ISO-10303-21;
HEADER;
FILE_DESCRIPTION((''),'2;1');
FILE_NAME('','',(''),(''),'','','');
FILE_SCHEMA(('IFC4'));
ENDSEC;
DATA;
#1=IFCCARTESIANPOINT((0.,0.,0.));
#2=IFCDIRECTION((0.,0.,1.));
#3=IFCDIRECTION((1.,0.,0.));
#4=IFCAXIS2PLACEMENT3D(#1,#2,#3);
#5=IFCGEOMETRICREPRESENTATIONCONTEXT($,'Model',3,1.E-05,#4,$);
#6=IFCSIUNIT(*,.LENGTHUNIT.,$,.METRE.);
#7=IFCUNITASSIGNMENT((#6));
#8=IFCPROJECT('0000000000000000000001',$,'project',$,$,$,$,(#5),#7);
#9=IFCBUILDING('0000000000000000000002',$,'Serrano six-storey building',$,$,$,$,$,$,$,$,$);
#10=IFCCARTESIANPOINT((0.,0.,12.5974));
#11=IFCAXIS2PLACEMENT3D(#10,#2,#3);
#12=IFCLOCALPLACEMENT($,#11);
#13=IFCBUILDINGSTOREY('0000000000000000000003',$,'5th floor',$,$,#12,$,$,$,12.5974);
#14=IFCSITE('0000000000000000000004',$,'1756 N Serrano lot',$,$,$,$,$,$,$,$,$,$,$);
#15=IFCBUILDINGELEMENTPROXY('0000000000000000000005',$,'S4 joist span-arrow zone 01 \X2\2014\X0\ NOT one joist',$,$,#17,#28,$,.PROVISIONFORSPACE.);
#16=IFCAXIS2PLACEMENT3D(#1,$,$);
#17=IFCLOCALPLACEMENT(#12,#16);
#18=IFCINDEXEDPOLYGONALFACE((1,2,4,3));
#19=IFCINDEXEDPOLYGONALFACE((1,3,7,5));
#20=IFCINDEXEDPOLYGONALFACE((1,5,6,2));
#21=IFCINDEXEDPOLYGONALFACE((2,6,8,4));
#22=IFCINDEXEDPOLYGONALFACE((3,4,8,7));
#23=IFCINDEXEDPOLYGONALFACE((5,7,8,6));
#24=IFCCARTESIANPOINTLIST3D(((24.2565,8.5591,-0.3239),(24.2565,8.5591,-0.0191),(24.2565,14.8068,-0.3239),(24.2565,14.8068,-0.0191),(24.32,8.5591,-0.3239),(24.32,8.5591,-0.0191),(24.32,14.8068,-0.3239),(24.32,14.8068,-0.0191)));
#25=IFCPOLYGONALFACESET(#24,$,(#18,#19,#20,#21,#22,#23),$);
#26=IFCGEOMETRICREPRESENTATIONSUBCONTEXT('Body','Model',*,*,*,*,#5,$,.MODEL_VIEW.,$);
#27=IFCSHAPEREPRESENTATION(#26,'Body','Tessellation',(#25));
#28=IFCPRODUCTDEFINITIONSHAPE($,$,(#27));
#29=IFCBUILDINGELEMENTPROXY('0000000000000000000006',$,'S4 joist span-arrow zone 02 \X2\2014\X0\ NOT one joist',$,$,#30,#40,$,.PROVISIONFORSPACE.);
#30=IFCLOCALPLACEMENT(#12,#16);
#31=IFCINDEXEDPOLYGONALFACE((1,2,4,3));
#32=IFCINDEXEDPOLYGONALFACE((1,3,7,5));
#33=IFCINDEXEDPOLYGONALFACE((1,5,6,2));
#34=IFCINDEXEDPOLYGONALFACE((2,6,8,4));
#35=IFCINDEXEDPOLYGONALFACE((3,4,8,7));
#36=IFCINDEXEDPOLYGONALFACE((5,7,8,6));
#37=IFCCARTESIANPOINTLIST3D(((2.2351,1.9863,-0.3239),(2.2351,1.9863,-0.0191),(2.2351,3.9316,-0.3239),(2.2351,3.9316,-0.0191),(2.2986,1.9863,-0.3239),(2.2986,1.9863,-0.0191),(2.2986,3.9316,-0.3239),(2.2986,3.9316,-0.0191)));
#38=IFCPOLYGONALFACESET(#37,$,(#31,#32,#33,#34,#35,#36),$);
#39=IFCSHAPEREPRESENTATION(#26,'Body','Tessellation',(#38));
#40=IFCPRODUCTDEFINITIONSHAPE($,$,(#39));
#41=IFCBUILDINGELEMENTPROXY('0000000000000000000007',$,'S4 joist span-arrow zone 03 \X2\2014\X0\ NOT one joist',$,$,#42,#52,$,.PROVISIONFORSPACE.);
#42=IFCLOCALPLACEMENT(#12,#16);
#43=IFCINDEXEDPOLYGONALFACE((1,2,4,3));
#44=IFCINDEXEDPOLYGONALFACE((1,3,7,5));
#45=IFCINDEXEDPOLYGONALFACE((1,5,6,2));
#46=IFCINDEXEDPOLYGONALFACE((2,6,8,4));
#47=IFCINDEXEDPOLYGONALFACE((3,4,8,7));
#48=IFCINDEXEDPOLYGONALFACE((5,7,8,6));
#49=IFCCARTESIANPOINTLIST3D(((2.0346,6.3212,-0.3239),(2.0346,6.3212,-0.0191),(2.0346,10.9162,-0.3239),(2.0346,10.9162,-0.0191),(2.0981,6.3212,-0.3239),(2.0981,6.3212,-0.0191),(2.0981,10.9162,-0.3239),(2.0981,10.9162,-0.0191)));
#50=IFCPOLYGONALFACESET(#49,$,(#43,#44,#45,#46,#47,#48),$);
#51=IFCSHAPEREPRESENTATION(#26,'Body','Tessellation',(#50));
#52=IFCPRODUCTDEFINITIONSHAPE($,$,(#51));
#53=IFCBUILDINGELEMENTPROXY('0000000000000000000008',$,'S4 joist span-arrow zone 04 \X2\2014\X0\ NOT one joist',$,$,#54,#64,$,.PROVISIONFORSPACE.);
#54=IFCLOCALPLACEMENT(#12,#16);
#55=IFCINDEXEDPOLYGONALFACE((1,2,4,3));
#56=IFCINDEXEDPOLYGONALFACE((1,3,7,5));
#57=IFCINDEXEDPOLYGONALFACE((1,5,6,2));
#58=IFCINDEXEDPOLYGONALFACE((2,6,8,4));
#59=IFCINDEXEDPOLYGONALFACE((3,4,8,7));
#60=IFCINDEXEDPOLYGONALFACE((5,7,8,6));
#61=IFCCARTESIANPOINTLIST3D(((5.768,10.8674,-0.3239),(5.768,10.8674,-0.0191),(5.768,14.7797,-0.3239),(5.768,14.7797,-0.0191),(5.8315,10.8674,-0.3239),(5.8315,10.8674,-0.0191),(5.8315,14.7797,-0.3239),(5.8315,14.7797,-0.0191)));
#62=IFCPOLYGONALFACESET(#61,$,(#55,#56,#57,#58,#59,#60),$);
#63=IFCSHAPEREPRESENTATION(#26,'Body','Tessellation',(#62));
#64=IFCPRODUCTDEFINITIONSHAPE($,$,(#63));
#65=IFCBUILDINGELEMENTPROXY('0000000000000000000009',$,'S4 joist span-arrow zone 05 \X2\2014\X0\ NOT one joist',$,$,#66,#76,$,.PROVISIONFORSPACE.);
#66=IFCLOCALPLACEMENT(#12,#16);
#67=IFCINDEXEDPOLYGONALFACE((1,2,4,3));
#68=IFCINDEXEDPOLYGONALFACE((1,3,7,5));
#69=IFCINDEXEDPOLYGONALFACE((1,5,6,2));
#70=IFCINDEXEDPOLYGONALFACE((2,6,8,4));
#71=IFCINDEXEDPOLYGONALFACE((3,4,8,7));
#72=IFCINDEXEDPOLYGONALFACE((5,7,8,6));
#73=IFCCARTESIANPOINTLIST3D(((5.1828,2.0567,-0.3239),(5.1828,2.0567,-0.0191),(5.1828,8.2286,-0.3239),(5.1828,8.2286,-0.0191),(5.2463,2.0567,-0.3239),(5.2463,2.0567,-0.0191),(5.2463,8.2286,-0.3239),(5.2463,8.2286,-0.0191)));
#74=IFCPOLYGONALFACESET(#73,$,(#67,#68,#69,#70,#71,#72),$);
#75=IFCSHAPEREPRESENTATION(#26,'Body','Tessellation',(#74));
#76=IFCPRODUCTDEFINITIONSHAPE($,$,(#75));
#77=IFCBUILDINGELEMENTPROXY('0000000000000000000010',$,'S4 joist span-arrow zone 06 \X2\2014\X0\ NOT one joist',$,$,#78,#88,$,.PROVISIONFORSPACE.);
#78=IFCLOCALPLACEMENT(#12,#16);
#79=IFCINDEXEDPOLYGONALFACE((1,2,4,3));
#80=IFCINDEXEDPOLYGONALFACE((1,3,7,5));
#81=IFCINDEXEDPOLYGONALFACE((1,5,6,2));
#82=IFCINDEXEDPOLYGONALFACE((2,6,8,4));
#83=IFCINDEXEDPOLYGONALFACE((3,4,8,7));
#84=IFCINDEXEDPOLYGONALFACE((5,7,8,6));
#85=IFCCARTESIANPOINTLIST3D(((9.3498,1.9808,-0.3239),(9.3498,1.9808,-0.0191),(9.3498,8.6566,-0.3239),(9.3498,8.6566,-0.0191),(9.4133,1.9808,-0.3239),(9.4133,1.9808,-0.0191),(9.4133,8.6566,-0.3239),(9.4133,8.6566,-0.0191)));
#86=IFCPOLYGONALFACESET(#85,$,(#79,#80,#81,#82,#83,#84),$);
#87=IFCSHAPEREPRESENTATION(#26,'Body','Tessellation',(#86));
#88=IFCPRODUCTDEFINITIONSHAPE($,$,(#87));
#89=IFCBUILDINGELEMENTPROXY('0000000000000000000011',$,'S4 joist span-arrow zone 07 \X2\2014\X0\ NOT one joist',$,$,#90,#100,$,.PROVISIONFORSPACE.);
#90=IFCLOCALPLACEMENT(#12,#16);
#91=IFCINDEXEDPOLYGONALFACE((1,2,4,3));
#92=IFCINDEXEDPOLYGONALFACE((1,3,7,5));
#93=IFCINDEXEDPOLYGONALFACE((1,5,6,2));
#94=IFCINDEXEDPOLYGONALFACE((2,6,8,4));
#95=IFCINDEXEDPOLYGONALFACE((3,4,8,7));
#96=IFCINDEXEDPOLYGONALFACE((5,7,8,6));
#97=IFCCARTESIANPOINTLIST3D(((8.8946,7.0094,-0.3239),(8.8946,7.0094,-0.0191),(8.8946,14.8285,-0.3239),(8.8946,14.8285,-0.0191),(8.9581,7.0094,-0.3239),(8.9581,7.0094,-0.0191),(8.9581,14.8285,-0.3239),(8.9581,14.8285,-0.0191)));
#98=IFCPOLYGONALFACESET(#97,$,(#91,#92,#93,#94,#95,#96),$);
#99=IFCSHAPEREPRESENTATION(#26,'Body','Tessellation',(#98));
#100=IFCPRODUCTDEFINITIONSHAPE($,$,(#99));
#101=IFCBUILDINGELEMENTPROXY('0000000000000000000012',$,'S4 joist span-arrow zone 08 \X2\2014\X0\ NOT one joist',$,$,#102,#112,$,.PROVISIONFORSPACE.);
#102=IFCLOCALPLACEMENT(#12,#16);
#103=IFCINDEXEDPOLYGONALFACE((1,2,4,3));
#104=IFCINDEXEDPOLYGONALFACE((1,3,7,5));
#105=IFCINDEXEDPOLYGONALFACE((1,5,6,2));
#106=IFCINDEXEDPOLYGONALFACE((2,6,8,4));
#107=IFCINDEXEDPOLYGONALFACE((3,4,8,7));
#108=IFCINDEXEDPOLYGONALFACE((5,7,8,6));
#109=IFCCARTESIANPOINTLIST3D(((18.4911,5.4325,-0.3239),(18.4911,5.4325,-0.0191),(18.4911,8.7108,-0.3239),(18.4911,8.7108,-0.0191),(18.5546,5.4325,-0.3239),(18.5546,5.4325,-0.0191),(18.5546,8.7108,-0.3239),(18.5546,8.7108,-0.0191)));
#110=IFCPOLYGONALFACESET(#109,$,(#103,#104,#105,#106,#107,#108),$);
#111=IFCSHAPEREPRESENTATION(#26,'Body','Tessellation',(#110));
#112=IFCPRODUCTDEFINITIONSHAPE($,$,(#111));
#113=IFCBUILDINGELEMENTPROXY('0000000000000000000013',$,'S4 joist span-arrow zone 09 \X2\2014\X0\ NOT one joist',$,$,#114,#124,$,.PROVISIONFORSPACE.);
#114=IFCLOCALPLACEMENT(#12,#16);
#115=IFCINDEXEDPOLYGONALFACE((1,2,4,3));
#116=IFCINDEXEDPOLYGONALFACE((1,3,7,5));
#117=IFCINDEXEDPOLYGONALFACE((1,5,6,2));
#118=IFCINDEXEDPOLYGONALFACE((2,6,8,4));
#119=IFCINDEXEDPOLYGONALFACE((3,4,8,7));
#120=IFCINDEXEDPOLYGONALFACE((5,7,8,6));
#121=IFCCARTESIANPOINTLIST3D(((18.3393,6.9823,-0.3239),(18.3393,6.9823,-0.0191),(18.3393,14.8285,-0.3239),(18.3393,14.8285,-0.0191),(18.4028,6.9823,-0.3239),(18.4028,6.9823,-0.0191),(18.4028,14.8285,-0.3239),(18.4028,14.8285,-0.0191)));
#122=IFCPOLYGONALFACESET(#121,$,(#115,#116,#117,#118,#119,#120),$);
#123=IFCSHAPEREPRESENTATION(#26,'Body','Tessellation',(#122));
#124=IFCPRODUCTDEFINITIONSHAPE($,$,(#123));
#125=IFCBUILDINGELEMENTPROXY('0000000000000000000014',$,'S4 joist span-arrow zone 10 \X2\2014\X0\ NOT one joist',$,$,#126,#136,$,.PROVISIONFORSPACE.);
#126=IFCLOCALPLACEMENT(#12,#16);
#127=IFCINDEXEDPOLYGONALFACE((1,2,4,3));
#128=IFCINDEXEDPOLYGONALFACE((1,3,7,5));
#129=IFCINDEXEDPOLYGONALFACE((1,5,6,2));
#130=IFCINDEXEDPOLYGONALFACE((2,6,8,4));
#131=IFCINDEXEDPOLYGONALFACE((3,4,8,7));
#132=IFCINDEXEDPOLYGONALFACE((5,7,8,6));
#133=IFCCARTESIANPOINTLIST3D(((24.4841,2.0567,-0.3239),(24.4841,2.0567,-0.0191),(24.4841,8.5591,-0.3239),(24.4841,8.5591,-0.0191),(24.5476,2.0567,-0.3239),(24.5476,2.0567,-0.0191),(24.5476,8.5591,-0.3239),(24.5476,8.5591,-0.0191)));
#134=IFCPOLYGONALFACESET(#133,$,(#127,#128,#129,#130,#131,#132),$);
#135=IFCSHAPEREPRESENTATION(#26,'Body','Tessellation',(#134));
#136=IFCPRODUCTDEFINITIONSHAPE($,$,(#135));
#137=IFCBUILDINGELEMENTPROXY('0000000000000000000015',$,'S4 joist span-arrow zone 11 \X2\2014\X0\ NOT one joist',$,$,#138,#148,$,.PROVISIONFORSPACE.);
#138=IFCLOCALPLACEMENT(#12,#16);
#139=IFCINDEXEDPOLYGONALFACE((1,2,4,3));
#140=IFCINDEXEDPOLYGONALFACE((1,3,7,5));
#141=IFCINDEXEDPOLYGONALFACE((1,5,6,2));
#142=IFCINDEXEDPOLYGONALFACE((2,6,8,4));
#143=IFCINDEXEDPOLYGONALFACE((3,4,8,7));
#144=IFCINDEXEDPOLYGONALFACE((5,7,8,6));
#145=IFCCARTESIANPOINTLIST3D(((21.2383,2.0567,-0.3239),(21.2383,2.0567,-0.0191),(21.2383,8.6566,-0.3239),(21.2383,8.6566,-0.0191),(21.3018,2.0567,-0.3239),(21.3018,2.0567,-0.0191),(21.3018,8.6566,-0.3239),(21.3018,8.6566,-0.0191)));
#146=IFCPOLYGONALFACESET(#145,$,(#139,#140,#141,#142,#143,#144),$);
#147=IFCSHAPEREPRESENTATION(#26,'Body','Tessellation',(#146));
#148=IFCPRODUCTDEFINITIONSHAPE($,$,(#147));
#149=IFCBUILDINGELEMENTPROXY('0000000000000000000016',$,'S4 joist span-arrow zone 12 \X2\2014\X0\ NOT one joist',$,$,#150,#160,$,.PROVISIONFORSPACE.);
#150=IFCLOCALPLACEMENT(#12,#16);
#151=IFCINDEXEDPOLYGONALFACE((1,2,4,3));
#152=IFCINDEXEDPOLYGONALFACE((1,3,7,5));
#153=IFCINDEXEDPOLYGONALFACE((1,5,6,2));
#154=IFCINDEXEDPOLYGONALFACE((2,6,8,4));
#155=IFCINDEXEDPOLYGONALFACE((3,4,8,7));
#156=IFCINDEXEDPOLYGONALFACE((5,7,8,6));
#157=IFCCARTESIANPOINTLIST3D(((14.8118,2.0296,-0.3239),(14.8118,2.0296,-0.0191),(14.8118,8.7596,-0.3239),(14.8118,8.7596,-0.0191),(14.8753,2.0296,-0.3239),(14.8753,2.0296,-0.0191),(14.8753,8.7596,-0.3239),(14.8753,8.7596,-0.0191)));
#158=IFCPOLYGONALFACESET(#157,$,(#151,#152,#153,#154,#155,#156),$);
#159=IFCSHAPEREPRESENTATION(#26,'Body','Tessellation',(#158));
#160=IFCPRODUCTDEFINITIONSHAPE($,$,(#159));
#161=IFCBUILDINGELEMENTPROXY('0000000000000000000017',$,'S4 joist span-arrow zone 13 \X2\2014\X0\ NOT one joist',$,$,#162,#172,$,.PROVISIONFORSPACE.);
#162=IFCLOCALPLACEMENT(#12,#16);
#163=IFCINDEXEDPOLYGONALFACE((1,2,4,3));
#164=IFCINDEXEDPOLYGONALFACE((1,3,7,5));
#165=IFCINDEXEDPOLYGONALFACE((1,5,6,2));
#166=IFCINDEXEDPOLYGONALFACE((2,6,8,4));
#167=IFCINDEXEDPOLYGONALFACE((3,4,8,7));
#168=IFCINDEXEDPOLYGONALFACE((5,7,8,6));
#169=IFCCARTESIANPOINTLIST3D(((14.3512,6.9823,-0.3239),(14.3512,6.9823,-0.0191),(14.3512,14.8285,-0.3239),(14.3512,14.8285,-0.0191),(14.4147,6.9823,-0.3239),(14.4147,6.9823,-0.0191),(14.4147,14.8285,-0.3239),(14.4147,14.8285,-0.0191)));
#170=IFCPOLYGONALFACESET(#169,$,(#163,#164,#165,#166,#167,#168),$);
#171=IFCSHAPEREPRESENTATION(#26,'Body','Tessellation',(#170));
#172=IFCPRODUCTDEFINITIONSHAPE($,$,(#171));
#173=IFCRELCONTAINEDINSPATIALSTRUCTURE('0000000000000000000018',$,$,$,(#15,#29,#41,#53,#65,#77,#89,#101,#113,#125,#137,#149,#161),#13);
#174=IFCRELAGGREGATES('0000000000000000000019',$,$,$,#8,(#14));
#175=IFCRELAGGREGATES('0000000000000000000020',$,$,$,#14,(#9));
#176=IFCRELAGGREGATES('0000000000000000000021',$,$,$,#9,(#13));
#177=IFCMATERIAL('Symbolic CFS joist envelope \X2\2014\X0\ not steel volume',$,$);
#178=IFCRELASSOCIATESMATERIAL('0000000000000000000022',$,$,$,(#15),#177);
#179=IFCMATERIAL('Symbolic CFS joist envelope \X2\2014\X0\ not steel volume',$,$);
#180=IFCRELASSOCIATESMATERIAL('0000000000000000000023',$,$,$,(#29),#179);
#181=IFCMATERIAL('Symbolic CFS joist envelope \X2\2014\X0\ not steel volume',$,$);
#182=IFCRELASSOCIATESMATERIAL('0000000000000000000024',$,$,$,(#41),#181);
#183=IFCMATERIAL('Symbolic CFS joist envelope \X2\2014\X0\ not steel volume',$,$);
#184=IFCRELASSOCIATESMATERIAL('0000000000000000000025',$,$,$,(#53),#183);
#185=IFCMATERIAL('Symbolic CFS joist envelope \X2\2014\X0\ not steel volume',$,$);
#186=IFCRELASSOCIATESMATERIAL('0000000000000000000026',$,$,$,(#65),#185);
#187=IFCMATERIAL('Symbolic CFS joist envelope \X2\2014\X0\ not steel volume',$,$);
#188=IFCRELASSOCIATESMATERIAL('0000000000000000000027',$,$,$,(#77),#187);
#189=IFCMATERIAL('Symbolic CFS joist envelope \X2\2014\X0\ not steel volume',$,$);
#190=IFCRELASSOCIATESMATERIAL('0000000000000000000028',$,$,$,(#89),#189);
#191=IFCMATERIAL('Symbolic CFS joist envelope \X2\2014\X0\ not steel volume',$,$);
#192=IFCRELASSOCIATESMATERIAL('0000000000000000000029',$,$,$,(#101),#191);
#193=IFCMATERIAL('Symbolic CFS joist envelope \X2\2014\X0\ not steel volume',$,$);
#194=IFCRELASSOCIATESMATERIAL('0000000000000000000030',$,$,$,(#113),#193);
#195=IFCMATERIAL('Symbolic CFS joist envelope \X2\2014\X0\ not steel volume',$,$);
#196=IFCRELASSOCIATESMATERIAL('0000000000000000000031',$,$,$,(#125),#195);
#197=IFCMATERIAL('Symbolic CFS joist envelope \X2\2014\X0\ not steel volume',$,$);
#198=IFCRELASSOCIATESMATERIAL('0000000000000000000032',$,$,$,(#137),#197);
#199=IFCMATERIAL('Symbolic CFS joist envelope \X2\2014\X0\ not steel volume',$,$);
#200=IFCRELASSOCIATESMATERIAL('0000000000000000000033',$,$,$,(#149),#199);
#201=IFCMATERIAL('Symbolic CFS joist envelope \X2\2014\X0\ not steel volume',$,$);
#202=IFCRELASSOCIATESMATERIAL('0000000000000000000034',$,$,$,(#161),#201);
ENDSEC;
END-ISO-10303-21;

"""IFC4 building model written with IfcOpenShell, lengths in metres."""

from ifc_helpers import new_model, si_unit, frame, origin_with_axes, place, context, subcontext, project, spatial, polyline, outline, extrude, material, element, save


model = new_model("IFC4")

# Units and contexts
model_context = context("Model", 3, precision=1e-05, world=origin_with_axes())
body_context = subcontext(model_context, "Body", "Model", "MODEL_VIEW")
ifc_project = project(units=[si_unit("LENGTHUNIT", "METRE")], contexts=[model_context])

# Site, building, storey
site = spatial("IfcSite", under=ifc_project, Name="1756 N Serrano lot")
building = spatial("IfcBuilding", under=site, Name="Serrano six-storey building")
storey_placement = place(None, frame((0.0, 0.0, 12.5974), z_axis=(0.0, 0.0, 1.0), x_axis=(1.0, 0.0, 0.0)))
storey = spatial("IfcBuildingStorey", under=building, at=storey_placement, Name="5th floor", Elevation=12.5974)

# Building element proxies
ifc_material_1 = material(Name="Symbolic CFS joist envelope — not steel volume")
proxy_1_placement = place(storey_placement, frame((0.0, 0.0, -12.5974), z_axis=(0.0, 0.0, 1.0), x_axis=(1.0, 0.0, 0.0)))
element("IfcBuildingElementProxy", 1, at=proxy_1_placement, inside=storey, material=ifc_material_1, Name="S4 joist span-arrow zone 01 — NOT one joist", PredefinedType="PROVISIONFORSPACE", context=body_context, shape_type="SweptSolid", body=[
    extrude(outline(polyline([(24.2565, 14.8068), (24.32, 14.8068), (24.32, 8.5591), (24.2565, 8.5591), (24.2565, 14.8068)])), frame((0.0, 0.0, 12.2735)), (0.0, 0.0, 1.0), 0.3048),
])
ifc_material_2 = material(Name="Symbolic CFS joist envelope — not steel volume")
proxy_2_placement = place(storey_placement, frame((0.0, 0.0, -12.5974), z_axis=(0.0, 0.0, 1.0), x_axis=(1.0, 0.0, 0.0)))
element("IfcBuildingElementProxy", 2, at=proxy_2_placement, inside=storey, material=ifc_material_2, Name="S4 joist span-arrow zone 02 — NOT one joist", PredefinedType="PROVISIONFORSPACE", context=body_context, shape_type="SweptSolid", body=[
    extrude(outline(polyline([(2.2351, 3.9316), (2.2986, 3.9316), (2.2986, 1.9863), (2.2351, 1.9863), (2.2351, 3.9316)])), frame((0.0, 0.0, 12.2735)), (0.0, 0.0, 1.0), 0.3048),
])
ifc_material_3 = material(Name="Symbolic CFS joist envelope — not steel volume")
proxy_3_placement = place(storey_placement, frame((0.0, 0.0, -12.5974), z_axis=(0.0, 0.0, 1.0), x_axis=(1.0, 0.0, 0.0)))
element("IfcBuildingElementProxy", 3, at=proxy_3_placement, inside=storey, material=ifc_material_3, Name="S4 joist span-arrow zone 03 — NOT one joist", PredefinedType="PROVISIONFORSPACE", context=body_context, shape_type="SweptSolid", body=[
    extrude(outline(polyline([(2.0346, 10.9162), (2.0981, 10.9162), (2.0981, 6.3212), (2.0346, 6.3212), (2.0346, 10.9162)])), frame((0.0, 0.0, 12.2735)), (0.0, 0.0, 1.0), 0.3048),
])
ifc_material_4 = material(Name="Symbolic CFS joist envelope — not steel volume")
proxy_4_placement = place(storey_placement, frame((0.0, 0.0, -12.5974), z_axis=(0.0, 0.0, 1.0), x_axis=(1.0, 0.0, 0.0)))
element("IfcBuildingElementProxy", 4, at=proxy_4_placement, inside=storey, material=ifc_material_4, Name="S4 joist span-arrow zone 04 — NOT one joist", PredefinedType="PROVISIONFORSPACE", context=body_context, shape_type="SweptSolid", body=[
    extrude(outline(polyline([(5.768, 14.7797), (5.8315, 14.7797), (5.8315, 10.8674), (5.768, 10.8674), (5.768, 14.7797)])), frame((0.0, 0.0, 12.2735)), (0.0, 0.0, 1.0), 0.3048),
])
ifc_material_5 = material(Name="Symbolic CFS joist envelope — not steel volume")
proxy_5_placement = place(storey_placement, frame((0.0, 0.0, -12.5974), z_axis=(0.0, 0.0, 1.0), x_axis=(1.0, 0.0, 0.0)))
element("IfcBuildingElementProxy", 5, at=proxy_5_placement, inside=storey, material=ifc_material_5, Name="S4 joist span-arrow zone 05 — NOT one joist", PredefinedType="PROVISIONFORSPACE", context=body_context, shape_type="SweptSolid", body=[
    extrude(outline(polyline([(5.1828, 8.2286), (5.2463, 8.2286), (5.2463, 2.0567), (5.1828, 2.0567), (5.1828, 8.2286)])), frame((0.0, 0.0, 12.2735)), (0.0, 0.0, 1.0), 0.3048),
])
ifc_material_6 = material(Name="Symbolic CFS joist envelope — not steel volume")
proxy_6_placement = place(storey_placement, frame((0.0, 0.0, -12.5974), z_axis=(0.0, 0.0, 1.0), x_axis=(1.0, 0.0, 0.0)))
element("IfcBuildingElementProxy", 6, at=proxy_6_placement, inside=storey, material=ifc_material_6, Name="S4 joist span-arrow zone 06 — NOT one joist", PredefinedType="PROVISIONFORSPACE", context=body_context, shape_type="SweptSolid", body=[
    extrude(outline(polyline([(9.3498, 8.6566), (9.4133, 8.6566), (9.4133, 1.9808), (9.3498, 1.9808), (9.3498, 8.6566)])), frame((0.0, 0.0, 12.2735)), (0.0, 0.0, 1.0), 0.3048),
])
ifc_material_7 = material(Name="Symbolic CFS joist envelope — not steel volume")
proxy_7_placement = place(storey_placement, frame((0.0, 0.0, -12.5974), z_axis=(0.0, 0.0, 1.0), x_axis=(1.0, 0.0, 0.0)))
element("IfcBuildingElementProxy", 7, at=proxy_7_placement, inside=storey, material=ifc_material_7, Name="S4 joist span-arrow zone 07 — NOT one joist", PredefinedType="PROVISIONFORSPACE", context=body_context, shape_type="SweptSolid", body=[
    extrude(outline(polyline([(8.8946, 14.8285), (8.9581, 14.8285), (8.9581, 7.0094), (8.8946, 7.0094), (8.8946, 14.8285)])), frame((0.0, 0.0, 12.2735)), (0.0, 0.0, 1.0), 0.3048),
])
ifc_material_8 = material(Name="Symbolic CFS joist envelope — not steel volume")
proxy_8_placement = place(storey_placement, frame((0.0, 0.0, -12.5974), z_axis=(0.0, 0.0, 1.0), x_axis=(1.0, 0.0, 0.0)))
element("IfcBuildingElementProxy", 8, at=proxy_8_placement, inside=storey, material=ifc_material_8, Name="S4 joist span-arrow zone 08 — NOT one joist", PredefinedType="PROVISIONFORSPACE", context=body_context, shape_type="SweptSolid", body=[
    extrude(outline(polyline([(18.4911, 8.7108), (18.5546, 8.7108), (18.5546, 5.4325), (18.4911, 5.4325), (18.4911, 8.7108)])), frame((0.0, 0.0, 12.2735)), (0.0, 0.0, 1.0), 0.3048),
])
ifc_material_9 = material(Name="Symbolic CFS joist envelope — not steel volume")
proxy_9_placement = place(storey_placement, frame((0.0, 0.0, -12.5974), z_axis=(0.0, 0.0, 1.0), x_axis=(1.0, 0.0, 0.0)))
element("IfcBuildingElementProxy", 9, at=proxy_9_placement, inside=storey, material=ifc_material_9, Name="S4 joist span-arrow zone 09 — NOT one joist", PredefinedType="PROVISIONFORSPACE", context=body_context, shape_type="SweptSolid", body=[
    extrude(outline(polyline([(18.3393, 14.8285), (18.4028, 14.8285), (18.4028, 6.9823), (18.3393, 6.9823), (18.3393, 14.8285)])), frame((0.0, 0.0, 12.2735)), (0.0, 0.0, 1.0), 0.3048),
])
ifc_material_10 = material(Name="Symbolic CFS joist envelope — not steel volume")
proxy_10_placement = place(storey_placement, frame((0.0, 0.0, -12.5974), z_axis=(0.0, 0.0, 1.0), x_axis=(1.0, 0.0, 0.0)))
element("IfcBuildingElementProxy", 10, at=proxy_10_placement, inside=storey, material=ifc_material_10, Name="S4 joist span-arrow zone 10 — NOT one joist", PredefinedType="PROVISIONFORSPACE", context=body_context, shape_type="SweptSolid", body=[
    extrude(outline(polyline([(24.4841, 8.5591), (24.5476, 8.5591), (24.5476, 2.0567), (24.4841, 2.0567), (24.4841, 8.5591)])), frame((0.0, 0.0, 12.2735)), (0.0, 0.0, 1.0), 0.3048),
])
ifc_material_11 = material(Name="Symbolic CFS joist envelope — not steel volume")
proxy_11_placement = place(storey_placement, frame((0.0, 0.0, -12.5974), z_axis=(0.0, 0.0, 1.0), x_axis=(1.0, 0.0, 0.0)))
element("IfcBuildingElementProxy", 11, at=proxy_11_placement, inside=storey, material=ifc_material_11, Name="S4 joist span-arrow zone 11 — NOT one joist", PredefinedType="PROVISIONFORSPACE", context=body_context, shape_type="SweptSolid", body=[
    extrude(outline(polyline([(21.2383, 8.6566), (21.3018, 8.6566), (21.3018, 2.0567), (21.2383, 2.0567), (21.2383, 8.6566)])), frame((0.0, 0.0, 12.2735)), (0.0, 0.0, 1.0), 0.3048),
])
ifc_material_12 = material(Name="Symbolic CFS joist envelope — not steel volume")
proxy_12_placement = place(storey_placement, frame((0.0, 0.0, -12.5974), z_axis=(0.0, 0.0, 1.0), x_axis=(1.0, 0.0, 0.0)))
element("IfcBuildingElementProxy", 12, at=proxy_12_placement, inside=storey, material=ifc_material_12, Name="S4 joist span-arrow zone 12 — NOT one joist", PredefinedType="PROVISIONFORSPACE", context=body_context, shape_type="SweptSolid", body=[
    extrude(outline(polyline([(14.8118, 8.7596), (14.8753, 8.7596), (14.8753, 2.0296), (14.8118, 2.0296), (14.8118, 8.7596)])), frame((0.0, 0.0, 12.2735)), (0.0, 0.0, 1.0), 0.3048),
])
ifc_material_13 = material(Name="Symbolic CFS joist envelope — not steel volume")
proxy_13_placement = place(storey_placement, frame((0.0, 0.0, -12.5974), z_axis=(0.0, 0.0, 1.0), x_axis=(1.0, 0.0, 0.0)))
element("IfcBuildingElementProxy", 13, at=proxy_13_placement, inside=storey, material=ifc_material_13, Name="S4 joist span-arrow zone 13 — NOT one joist", PredefinedType="PROVISIONFORSPACE", context=body_context, shape_type="SweptSolid", body=[
    extrude(outline(polyline([(14.3512, 14.8285), (14.4147, 14.8285), (14.4147, 6.9823), (14.3512, 6.9823), (14.3512, 14.8285)])), frame((0.0, 0.0, 12.2735)), (0.0, 0.0, 1.0), 0.3048),
])

save(model, "model.ifc")
